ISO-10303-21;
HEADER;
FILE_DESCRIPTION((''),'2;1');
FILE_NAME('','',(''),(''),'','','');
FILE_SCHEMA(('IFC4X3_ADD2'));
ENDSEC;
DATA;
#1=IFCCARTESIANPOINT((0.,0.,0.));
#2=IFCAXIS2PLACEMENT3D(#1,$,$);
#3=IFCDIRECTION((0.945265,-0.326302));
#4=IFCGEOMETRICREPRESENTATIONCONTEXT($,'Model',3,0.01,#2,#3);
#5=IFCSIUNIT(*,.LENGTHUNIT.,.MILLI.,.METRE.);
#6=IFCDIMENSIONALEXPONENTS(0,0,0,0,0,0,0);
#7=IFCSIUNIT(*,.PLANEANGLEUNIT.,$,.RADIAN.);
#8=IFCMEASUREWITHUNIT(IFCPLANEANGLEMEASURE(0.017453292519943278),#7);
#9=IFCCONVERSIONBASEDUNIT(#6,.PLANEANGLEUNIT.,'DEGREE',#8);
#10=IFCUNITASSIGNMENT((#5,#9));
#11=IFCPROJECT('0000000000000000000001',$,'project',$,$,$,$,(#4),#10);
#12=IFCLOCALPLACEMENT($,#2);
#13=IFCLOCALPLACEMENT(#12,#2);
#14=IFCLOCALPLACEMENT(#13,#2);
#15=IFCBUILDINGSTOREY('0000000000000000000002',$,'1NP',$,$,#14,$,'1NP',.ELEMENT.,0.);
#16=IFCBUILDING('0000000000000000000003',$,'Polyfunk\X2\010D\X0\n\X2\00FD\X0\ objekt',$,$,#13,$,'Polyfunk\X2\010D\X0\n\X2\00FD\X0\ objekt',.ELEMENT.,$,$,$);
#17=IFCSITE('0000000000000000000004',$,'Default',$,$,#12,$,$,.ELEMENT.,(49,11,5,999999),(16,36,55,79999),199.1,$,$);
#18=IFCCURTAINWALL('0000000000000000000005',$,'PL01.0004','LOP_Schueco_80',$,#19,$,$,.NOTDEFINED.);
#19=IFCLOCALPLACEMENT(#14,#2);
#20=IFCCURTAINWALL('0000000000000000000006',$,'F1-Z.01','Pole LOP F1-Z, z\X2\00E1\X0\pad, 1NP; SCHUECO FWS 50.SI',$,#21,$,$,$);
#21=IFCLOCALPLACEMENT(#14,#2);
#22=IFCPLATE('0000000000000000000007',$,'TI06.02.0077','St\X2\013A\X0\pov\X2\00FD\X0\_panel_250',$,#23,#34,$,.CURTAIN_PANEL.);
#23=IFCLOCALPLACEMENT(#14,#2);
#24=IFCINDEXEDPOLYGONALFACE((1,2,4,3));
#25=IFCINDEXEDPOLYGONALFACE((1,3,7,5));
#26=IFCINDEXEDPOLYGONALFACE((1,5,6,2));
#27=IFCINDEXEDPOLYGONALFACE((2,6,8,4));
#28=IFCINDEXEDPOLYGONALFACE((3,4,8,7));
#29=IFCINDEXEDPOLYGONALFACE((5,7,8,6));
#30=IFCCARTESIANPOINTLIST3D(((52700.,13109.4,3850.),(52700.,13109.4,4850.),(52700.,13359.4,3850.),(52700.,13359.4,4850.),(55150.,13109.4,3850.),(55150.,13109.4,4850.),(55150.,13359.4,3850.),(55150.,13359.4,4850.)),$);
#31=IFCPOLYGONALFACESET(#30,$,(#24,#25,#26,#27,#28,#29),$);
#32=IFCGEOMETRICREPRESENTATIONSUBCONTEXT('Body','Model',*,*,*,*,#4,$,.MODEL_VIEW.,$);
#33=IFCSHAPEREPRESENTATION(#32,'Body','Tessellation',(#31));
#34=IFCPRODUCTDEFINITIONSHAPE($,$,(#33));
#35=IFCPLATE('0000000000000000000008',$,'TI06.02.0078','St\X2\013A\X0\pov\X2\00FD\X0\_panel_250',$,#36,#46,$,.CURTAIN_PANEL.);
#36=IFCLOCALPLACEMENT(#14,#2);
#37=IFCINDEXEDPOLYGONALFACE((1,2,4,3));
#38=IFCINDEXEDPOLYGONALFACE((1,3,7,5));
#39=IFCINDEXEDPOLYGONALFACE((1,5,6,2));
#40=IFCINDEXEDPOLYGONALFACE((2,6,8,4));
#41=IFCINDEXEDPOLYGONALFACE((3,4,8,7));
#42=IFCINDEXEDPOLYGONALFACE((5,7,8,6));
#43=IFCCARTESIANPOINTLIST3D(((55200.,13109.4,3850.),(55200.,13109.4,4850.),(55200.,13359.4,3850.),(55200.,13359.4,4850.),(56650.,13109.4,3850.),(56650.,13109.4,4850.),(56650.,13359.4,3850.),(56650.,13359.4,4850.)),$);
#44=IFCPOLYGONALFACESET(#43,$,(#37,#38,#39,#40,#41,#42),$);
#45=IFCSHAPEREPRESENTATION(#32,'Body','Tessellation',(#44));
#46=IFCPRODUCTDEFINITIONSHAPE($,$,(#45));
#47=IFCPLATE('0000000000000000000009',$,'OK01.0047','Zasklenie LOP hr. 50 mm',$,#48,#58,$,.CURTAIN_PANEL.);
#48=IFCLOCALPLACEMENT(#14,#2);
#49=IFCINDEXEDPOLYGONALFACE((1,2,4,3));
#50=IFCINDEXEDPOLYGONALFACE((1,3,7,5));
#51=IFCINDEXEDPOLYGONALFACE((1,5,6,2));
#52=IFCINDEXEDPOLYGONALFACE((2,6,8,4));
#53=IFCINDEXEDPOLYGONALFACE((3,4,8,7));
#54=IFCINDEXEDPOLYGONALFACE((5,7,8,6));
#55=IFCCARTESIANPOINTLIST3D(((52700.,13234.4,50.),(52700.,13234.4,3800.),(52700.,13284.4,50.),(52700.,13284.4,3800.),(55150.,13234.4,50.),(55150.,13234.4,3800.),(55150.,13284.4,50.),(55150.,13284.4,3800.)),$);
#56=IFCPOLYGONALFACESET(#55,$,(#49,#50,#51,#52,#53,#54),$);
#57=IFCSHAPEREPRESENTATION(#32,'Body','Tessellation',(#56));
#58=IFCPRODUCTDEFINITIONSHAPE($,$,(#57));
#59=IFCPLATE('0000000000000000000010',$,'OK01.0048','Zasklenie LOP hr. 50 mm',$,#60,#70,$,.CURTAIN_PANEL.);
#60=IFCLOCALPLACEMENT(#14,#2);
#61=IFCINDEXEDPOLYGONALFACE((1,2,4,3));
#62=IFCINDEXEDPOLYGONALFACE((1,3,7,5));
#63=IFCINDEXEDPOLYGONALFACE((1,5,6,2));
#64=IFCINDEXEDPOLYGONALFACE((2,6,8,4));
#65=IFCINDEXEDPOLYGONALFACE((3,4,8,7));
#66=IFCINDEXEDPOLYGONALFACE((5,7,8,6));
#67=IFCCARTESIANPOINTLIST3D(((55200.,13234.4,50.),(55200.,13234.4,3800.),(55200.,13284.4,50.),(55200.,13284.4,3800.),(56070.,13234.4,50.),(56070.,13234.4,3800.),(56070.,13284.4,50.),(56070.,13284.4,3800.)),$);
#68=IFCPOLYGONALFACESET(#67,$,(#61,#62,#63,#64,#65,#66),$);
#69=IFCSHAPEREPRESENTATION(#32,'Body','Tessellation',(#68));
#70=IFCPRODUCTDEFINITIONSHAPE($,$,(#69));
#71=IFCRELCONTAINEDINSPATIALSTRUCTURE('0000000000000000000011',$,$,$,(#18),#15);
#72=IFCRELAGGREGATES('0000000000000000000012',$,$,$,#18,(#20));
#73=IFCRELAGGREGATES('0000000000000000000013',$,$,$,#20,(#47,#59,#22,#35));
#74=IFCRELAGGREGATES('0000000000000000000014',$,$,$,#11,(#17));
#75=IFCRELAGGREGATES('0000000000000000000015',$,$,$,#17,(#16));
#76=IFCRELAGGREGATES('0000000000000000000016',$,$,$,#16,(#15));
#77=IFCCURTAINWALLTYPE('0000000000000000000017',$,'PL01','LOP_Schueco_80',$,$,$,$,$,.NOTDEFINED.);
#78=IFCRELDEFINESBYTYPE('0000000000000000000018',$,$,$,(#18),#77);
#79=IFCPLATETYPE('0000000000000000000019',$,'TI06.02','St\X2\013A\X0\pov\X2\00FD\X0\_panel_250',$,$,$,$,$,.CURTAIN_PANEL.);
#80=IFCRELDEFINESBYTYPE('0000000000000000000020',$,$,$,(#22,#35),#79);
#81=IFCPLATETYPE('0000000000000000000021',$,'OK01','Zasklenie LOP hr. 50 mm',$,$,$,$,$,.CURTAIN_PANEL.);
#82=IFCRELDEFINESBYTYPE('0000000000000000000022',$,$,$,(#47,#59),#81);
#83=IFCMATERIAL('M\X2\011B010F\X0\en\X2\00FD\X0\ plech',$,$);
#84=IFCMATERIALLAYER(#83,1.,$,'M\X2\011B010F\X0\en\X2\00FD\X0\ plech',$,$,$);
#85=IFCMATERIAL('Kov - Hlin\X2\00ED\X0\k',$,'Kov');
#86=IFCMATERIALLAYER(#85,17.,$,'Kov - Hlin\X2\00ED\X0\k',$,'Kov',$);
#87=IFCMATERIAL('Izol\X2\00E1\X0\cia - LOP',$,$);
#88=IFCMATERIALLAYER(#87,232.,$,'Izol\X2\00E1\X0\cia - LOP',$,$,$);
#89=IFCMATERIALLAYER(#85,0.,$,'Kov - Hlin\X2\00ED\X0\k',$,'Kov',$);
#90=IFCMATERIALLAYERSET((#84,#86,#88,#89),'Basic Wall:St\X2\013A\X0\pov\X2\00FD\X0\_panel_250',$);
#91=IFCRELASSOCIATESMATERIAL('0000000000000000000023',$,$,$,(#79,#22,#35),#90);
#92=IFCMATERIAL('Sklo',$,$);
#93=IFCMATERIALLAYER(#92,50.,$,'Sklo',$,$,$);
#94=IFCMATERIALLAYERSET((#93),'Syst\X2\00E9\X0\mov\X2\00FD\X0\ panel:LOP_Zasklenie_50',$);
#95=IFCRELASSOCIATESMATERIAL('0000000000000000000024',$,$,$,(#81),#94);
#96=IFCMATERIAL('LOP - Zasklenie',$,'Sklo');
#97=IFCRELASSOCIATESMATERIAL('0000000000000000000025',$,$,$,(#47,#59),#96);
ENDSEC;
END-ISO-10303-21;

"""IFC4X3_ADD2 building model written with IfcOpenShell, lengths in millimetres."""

from ifc_helpers import new_model, entity, si_unit, converted_unit, direction, frame, frame_2d, origin, origin_2d_with_axis, place, context, subcontext, project, spatial, rectangle, extrude, source, transform, mapped, material, layer, layer_set, layer_usage, type_object, type_shapes, element, aggregate, save


model = new_model("IFC4X3_ADD2")

# Units and contexts
model_context = context("Model", 3, precision=0.01, world=origin(), true_north=direction((0.945265, -0.326302)))
body_context = subcontext(model_context, "Body", "Model", "MODEL_VIEW")
ifc_project = project(units=[si_unit("LENGTHUNIT", "METRE", prefix="MILLI"), converted_unit("PLANEANGLEUNIT", "DEGREE", entity("IfcPlaneAngleMeasure", 0.017453292519943278), si_unit("PLANEANGLEUNIT", "RADIAN"), dimensions=[0, 0, 0, 0, 0, 0, 0])], contexts=[model_context])

# Site, building, storey
site_placement = place(None, origin())
site = spatial("IfcSite", under=ifc_project, at=site_placement, Name="Default", CompositionType="ELEMENT", RefLatitude=(49, 11, 5, 999999), RefLongitude=(16, 36, 55, 79999), RefElevation=199.1)
building_placement = place(site_placement, origin())
building = spatial("IfcBuilding", under=site, at=building_placement, Name="Polyfunkčný objekt", LongName="Polyfunkčný objekt", CompositionType="ELEMENT")
storey_placement = place(building_placement, origin())
storey = spatial("IfcBuildingStorey", under=building, at=storey_placement, Name="1NP", LongName="1NP", CompositionType="ELEMENT", Elevation=0.0)

# Curtain walls, plates
curtain_wall_type = type_object("IfcCurtainWallType", Name="PL01", Description="LOP_Schueco_80", PredefinedType="NOTDEFINED")
curtain_wall_1_placement = place(storey_placement, origin())
curtain_wall_1 = element("IfcCurtainWall", 1, at=curtain_wall_1_placement, inside=storey, type_object=curtain_wall_type, Name="PL01.0004", Description="LOP_Schueco_80", PredefinedType="NOTDEFINED")
curtain_wall_2 = element("IfcCurtainWall", 2, Name="F1-Z.01", Description="Pole LOP F1-Z, západ, 1NP; SCHUECO FWS 50.SI")
aggregate(curtain_wall_1, [curtain_wall_2])
ifc_material_1 = material(Name="Měďený plech")
ifc_layer_1 = layer(ifc_material_1, 1.0, Name="Měďený plech")
ifc_material_2 = material(Name="Kov - Hliník", Category="Kov")
ifc_layer_2 = layer(ifc_material_2, 17.0, Name="Kov - Hliník", Category="Kov")
ifc_material_3 = material(Name="Izolácia - LOP")
ifc_layer_3 = layer(ifc_material_3, 232.0, Name="Izolácia - LOP")
ifc_layer_4 = layer(ifc_material_2, 0.0, Name="Kov - Hliník", Category="Kov")
ifc_layer_set_1 = layer_set([ifc_layer_1, ifc_layer_2, ifc_layer_3, ifc_layer_4], Name="Basic Wall:Stĺpový_panel_250")
ifc_layer_usage_1 = layer_usage(ifc_layer_set_1, "AXIS2", "NEGATIVE", 125.0)
plate_type_1 = type_object("IfcPlateType", Name="TI06.02", Description="Stĺpový_panel_250", PredefinedType="CURTAIN_PANEL", material=ifc_layer_set_1)
plate_1_placement = place(storey_placement, frame((52700.0, 13234.4, 3850.0)))
plate_1 = element("IfcPlate", 3, at=plate_1_placement, type_object=plate_type_1, material=ifc_layer_usage_1, Name="TI06.02.0077", Description="Stĺpový_panel_250", PredefinedType="CURTAIN_PANEL", context=body_context, shape_type="SweptSolid", body=[
    extrude(rectangle(XDim=250.0, YDim=2450.0, at=origin_2d_with_axis()), frame((1225.0, 0.0, 0.0), z_axis=(0.0, 0.0, 1.0), x_axis=(0.0, 1.0, 0.0)), (0.0, 0.0, 1.0), 1000.0),
])
ifc_layer_usage_2 = layer_usage(ifc_layer_set_1, "AXIS2", "NEGATIVE", 125.0)
plate_2_placement = place(storey_placement, frame((55200.0, 13234.4, 3850.0)))
plate_2 = element("IfcPlate", 4, at=plate_2_placement, type_object=plate_type_1, material=ifc_layer_usage_2, Name="TI06.02.0078", Description="Stĺpový_panel_250", PredefinedType="CURTAIN_PANEL", context=body_context, shape_type="SweptSolid", body=[
    extrude(rectangle(XDim=250.0, YDim=1450.0, at=origin_2d_with_axis()), frame((725.0, 0.0, 0.0), z_axis=(0.0, 0.0, 1.0), x_axis=(0.0, 1.0, 0.0)), (0.0, 0.0, 1.0), 1000.0),
])
ifc_material_4 = material(Name="LOP - Zasklenie", Category="Sklo")
ifc_material_5 = material(Name="Sklo")
ifc_layer_5 = layer(ifc_material_5, 50.0, Name="Sklo")
ifc_layer_set_2 = layer_set([ifc_layer_5], Name="Systémový panel:LOP_Zasklenie_50")
plate_type_2 = type_object("IfcPlateType", Name="OK01", Description="Zasklenie LOP hr. 50 mm", PredefinedType="CURTAIN_PANEL", material=ifc_layer_set_2)
shared_shape_1 = source(origin(), body_context, "Body", "SweptSolid", [
    extrude(rectangle(XDim=3750.0, YDim=2450.0, at=frame_2d((-141.7, 0.0), x_axis=(1.0, 0.0))), frame((0.0, 0.0, 2016.7), z_axis=(0.0, 1.0, 0.0), x_axis=(0.0, 0.0, 1.0)), (0.0, 0.0, 1.0), 50.0),
])
plate_3_placement = place(curtain_wall_1_placement, frame((53925.0, 13234.4, 50.0)))
plate_3 = element("IfcPlate", 5, at=plate_3_placement, type_object=plate_type_2, material=ifc_material_4, Name="OK01.0047", Description="Zasklenie LOP hr. 50 mm", PredefinedType="CURTAIN_PANEL", context=body_context, shape_type="MappedRepresentation", body=[
    mapped(shared_shape_1, transform((0.0, 0.0, 0.0), scale=1.0)),
])
shared_shape_2 = source(origin(), body_context, "Body", "SweptSolid", [
    extrude(rectangle(XDim=3750.0, YDim=870.0, at=frame_2d((-141.7, 0.0), x_axis=(1.0, 0.0))), frame((0.0, 0.0, 2016.7), z_axis=(0.0, 1.0, 0.0), x_axis=(0.0, 0.0, 1.0)), (0.0, 0.0, 1.0), 50.0),
])
type_shapes(plate_type_2, [shared_shape_1, shared_shape_2])
plate_4_placement = place(curtain_wall_1_placement, frame((55635.0, 13234.4, 50.0)))
plate_4 = element("IfcPlate", 6, at=plate_4_placement, type_object=plate_type_2, material=ifc_material_4, Name="OK01.0048", Description="Zasklenie LOP hr. 50 mm", PredefinedType="CURTAIN_PANEL", context=body_context, shape_type="MappedRepresentation", body=[
    mapped(shared_shape_2, transform((0.0, 0.0, 0.0), scale=1.0)),
])
aggregate(curtain_wall_2, [plate_3, plate_4, plate_1, plate_2])

save(model, "model.ifc")
